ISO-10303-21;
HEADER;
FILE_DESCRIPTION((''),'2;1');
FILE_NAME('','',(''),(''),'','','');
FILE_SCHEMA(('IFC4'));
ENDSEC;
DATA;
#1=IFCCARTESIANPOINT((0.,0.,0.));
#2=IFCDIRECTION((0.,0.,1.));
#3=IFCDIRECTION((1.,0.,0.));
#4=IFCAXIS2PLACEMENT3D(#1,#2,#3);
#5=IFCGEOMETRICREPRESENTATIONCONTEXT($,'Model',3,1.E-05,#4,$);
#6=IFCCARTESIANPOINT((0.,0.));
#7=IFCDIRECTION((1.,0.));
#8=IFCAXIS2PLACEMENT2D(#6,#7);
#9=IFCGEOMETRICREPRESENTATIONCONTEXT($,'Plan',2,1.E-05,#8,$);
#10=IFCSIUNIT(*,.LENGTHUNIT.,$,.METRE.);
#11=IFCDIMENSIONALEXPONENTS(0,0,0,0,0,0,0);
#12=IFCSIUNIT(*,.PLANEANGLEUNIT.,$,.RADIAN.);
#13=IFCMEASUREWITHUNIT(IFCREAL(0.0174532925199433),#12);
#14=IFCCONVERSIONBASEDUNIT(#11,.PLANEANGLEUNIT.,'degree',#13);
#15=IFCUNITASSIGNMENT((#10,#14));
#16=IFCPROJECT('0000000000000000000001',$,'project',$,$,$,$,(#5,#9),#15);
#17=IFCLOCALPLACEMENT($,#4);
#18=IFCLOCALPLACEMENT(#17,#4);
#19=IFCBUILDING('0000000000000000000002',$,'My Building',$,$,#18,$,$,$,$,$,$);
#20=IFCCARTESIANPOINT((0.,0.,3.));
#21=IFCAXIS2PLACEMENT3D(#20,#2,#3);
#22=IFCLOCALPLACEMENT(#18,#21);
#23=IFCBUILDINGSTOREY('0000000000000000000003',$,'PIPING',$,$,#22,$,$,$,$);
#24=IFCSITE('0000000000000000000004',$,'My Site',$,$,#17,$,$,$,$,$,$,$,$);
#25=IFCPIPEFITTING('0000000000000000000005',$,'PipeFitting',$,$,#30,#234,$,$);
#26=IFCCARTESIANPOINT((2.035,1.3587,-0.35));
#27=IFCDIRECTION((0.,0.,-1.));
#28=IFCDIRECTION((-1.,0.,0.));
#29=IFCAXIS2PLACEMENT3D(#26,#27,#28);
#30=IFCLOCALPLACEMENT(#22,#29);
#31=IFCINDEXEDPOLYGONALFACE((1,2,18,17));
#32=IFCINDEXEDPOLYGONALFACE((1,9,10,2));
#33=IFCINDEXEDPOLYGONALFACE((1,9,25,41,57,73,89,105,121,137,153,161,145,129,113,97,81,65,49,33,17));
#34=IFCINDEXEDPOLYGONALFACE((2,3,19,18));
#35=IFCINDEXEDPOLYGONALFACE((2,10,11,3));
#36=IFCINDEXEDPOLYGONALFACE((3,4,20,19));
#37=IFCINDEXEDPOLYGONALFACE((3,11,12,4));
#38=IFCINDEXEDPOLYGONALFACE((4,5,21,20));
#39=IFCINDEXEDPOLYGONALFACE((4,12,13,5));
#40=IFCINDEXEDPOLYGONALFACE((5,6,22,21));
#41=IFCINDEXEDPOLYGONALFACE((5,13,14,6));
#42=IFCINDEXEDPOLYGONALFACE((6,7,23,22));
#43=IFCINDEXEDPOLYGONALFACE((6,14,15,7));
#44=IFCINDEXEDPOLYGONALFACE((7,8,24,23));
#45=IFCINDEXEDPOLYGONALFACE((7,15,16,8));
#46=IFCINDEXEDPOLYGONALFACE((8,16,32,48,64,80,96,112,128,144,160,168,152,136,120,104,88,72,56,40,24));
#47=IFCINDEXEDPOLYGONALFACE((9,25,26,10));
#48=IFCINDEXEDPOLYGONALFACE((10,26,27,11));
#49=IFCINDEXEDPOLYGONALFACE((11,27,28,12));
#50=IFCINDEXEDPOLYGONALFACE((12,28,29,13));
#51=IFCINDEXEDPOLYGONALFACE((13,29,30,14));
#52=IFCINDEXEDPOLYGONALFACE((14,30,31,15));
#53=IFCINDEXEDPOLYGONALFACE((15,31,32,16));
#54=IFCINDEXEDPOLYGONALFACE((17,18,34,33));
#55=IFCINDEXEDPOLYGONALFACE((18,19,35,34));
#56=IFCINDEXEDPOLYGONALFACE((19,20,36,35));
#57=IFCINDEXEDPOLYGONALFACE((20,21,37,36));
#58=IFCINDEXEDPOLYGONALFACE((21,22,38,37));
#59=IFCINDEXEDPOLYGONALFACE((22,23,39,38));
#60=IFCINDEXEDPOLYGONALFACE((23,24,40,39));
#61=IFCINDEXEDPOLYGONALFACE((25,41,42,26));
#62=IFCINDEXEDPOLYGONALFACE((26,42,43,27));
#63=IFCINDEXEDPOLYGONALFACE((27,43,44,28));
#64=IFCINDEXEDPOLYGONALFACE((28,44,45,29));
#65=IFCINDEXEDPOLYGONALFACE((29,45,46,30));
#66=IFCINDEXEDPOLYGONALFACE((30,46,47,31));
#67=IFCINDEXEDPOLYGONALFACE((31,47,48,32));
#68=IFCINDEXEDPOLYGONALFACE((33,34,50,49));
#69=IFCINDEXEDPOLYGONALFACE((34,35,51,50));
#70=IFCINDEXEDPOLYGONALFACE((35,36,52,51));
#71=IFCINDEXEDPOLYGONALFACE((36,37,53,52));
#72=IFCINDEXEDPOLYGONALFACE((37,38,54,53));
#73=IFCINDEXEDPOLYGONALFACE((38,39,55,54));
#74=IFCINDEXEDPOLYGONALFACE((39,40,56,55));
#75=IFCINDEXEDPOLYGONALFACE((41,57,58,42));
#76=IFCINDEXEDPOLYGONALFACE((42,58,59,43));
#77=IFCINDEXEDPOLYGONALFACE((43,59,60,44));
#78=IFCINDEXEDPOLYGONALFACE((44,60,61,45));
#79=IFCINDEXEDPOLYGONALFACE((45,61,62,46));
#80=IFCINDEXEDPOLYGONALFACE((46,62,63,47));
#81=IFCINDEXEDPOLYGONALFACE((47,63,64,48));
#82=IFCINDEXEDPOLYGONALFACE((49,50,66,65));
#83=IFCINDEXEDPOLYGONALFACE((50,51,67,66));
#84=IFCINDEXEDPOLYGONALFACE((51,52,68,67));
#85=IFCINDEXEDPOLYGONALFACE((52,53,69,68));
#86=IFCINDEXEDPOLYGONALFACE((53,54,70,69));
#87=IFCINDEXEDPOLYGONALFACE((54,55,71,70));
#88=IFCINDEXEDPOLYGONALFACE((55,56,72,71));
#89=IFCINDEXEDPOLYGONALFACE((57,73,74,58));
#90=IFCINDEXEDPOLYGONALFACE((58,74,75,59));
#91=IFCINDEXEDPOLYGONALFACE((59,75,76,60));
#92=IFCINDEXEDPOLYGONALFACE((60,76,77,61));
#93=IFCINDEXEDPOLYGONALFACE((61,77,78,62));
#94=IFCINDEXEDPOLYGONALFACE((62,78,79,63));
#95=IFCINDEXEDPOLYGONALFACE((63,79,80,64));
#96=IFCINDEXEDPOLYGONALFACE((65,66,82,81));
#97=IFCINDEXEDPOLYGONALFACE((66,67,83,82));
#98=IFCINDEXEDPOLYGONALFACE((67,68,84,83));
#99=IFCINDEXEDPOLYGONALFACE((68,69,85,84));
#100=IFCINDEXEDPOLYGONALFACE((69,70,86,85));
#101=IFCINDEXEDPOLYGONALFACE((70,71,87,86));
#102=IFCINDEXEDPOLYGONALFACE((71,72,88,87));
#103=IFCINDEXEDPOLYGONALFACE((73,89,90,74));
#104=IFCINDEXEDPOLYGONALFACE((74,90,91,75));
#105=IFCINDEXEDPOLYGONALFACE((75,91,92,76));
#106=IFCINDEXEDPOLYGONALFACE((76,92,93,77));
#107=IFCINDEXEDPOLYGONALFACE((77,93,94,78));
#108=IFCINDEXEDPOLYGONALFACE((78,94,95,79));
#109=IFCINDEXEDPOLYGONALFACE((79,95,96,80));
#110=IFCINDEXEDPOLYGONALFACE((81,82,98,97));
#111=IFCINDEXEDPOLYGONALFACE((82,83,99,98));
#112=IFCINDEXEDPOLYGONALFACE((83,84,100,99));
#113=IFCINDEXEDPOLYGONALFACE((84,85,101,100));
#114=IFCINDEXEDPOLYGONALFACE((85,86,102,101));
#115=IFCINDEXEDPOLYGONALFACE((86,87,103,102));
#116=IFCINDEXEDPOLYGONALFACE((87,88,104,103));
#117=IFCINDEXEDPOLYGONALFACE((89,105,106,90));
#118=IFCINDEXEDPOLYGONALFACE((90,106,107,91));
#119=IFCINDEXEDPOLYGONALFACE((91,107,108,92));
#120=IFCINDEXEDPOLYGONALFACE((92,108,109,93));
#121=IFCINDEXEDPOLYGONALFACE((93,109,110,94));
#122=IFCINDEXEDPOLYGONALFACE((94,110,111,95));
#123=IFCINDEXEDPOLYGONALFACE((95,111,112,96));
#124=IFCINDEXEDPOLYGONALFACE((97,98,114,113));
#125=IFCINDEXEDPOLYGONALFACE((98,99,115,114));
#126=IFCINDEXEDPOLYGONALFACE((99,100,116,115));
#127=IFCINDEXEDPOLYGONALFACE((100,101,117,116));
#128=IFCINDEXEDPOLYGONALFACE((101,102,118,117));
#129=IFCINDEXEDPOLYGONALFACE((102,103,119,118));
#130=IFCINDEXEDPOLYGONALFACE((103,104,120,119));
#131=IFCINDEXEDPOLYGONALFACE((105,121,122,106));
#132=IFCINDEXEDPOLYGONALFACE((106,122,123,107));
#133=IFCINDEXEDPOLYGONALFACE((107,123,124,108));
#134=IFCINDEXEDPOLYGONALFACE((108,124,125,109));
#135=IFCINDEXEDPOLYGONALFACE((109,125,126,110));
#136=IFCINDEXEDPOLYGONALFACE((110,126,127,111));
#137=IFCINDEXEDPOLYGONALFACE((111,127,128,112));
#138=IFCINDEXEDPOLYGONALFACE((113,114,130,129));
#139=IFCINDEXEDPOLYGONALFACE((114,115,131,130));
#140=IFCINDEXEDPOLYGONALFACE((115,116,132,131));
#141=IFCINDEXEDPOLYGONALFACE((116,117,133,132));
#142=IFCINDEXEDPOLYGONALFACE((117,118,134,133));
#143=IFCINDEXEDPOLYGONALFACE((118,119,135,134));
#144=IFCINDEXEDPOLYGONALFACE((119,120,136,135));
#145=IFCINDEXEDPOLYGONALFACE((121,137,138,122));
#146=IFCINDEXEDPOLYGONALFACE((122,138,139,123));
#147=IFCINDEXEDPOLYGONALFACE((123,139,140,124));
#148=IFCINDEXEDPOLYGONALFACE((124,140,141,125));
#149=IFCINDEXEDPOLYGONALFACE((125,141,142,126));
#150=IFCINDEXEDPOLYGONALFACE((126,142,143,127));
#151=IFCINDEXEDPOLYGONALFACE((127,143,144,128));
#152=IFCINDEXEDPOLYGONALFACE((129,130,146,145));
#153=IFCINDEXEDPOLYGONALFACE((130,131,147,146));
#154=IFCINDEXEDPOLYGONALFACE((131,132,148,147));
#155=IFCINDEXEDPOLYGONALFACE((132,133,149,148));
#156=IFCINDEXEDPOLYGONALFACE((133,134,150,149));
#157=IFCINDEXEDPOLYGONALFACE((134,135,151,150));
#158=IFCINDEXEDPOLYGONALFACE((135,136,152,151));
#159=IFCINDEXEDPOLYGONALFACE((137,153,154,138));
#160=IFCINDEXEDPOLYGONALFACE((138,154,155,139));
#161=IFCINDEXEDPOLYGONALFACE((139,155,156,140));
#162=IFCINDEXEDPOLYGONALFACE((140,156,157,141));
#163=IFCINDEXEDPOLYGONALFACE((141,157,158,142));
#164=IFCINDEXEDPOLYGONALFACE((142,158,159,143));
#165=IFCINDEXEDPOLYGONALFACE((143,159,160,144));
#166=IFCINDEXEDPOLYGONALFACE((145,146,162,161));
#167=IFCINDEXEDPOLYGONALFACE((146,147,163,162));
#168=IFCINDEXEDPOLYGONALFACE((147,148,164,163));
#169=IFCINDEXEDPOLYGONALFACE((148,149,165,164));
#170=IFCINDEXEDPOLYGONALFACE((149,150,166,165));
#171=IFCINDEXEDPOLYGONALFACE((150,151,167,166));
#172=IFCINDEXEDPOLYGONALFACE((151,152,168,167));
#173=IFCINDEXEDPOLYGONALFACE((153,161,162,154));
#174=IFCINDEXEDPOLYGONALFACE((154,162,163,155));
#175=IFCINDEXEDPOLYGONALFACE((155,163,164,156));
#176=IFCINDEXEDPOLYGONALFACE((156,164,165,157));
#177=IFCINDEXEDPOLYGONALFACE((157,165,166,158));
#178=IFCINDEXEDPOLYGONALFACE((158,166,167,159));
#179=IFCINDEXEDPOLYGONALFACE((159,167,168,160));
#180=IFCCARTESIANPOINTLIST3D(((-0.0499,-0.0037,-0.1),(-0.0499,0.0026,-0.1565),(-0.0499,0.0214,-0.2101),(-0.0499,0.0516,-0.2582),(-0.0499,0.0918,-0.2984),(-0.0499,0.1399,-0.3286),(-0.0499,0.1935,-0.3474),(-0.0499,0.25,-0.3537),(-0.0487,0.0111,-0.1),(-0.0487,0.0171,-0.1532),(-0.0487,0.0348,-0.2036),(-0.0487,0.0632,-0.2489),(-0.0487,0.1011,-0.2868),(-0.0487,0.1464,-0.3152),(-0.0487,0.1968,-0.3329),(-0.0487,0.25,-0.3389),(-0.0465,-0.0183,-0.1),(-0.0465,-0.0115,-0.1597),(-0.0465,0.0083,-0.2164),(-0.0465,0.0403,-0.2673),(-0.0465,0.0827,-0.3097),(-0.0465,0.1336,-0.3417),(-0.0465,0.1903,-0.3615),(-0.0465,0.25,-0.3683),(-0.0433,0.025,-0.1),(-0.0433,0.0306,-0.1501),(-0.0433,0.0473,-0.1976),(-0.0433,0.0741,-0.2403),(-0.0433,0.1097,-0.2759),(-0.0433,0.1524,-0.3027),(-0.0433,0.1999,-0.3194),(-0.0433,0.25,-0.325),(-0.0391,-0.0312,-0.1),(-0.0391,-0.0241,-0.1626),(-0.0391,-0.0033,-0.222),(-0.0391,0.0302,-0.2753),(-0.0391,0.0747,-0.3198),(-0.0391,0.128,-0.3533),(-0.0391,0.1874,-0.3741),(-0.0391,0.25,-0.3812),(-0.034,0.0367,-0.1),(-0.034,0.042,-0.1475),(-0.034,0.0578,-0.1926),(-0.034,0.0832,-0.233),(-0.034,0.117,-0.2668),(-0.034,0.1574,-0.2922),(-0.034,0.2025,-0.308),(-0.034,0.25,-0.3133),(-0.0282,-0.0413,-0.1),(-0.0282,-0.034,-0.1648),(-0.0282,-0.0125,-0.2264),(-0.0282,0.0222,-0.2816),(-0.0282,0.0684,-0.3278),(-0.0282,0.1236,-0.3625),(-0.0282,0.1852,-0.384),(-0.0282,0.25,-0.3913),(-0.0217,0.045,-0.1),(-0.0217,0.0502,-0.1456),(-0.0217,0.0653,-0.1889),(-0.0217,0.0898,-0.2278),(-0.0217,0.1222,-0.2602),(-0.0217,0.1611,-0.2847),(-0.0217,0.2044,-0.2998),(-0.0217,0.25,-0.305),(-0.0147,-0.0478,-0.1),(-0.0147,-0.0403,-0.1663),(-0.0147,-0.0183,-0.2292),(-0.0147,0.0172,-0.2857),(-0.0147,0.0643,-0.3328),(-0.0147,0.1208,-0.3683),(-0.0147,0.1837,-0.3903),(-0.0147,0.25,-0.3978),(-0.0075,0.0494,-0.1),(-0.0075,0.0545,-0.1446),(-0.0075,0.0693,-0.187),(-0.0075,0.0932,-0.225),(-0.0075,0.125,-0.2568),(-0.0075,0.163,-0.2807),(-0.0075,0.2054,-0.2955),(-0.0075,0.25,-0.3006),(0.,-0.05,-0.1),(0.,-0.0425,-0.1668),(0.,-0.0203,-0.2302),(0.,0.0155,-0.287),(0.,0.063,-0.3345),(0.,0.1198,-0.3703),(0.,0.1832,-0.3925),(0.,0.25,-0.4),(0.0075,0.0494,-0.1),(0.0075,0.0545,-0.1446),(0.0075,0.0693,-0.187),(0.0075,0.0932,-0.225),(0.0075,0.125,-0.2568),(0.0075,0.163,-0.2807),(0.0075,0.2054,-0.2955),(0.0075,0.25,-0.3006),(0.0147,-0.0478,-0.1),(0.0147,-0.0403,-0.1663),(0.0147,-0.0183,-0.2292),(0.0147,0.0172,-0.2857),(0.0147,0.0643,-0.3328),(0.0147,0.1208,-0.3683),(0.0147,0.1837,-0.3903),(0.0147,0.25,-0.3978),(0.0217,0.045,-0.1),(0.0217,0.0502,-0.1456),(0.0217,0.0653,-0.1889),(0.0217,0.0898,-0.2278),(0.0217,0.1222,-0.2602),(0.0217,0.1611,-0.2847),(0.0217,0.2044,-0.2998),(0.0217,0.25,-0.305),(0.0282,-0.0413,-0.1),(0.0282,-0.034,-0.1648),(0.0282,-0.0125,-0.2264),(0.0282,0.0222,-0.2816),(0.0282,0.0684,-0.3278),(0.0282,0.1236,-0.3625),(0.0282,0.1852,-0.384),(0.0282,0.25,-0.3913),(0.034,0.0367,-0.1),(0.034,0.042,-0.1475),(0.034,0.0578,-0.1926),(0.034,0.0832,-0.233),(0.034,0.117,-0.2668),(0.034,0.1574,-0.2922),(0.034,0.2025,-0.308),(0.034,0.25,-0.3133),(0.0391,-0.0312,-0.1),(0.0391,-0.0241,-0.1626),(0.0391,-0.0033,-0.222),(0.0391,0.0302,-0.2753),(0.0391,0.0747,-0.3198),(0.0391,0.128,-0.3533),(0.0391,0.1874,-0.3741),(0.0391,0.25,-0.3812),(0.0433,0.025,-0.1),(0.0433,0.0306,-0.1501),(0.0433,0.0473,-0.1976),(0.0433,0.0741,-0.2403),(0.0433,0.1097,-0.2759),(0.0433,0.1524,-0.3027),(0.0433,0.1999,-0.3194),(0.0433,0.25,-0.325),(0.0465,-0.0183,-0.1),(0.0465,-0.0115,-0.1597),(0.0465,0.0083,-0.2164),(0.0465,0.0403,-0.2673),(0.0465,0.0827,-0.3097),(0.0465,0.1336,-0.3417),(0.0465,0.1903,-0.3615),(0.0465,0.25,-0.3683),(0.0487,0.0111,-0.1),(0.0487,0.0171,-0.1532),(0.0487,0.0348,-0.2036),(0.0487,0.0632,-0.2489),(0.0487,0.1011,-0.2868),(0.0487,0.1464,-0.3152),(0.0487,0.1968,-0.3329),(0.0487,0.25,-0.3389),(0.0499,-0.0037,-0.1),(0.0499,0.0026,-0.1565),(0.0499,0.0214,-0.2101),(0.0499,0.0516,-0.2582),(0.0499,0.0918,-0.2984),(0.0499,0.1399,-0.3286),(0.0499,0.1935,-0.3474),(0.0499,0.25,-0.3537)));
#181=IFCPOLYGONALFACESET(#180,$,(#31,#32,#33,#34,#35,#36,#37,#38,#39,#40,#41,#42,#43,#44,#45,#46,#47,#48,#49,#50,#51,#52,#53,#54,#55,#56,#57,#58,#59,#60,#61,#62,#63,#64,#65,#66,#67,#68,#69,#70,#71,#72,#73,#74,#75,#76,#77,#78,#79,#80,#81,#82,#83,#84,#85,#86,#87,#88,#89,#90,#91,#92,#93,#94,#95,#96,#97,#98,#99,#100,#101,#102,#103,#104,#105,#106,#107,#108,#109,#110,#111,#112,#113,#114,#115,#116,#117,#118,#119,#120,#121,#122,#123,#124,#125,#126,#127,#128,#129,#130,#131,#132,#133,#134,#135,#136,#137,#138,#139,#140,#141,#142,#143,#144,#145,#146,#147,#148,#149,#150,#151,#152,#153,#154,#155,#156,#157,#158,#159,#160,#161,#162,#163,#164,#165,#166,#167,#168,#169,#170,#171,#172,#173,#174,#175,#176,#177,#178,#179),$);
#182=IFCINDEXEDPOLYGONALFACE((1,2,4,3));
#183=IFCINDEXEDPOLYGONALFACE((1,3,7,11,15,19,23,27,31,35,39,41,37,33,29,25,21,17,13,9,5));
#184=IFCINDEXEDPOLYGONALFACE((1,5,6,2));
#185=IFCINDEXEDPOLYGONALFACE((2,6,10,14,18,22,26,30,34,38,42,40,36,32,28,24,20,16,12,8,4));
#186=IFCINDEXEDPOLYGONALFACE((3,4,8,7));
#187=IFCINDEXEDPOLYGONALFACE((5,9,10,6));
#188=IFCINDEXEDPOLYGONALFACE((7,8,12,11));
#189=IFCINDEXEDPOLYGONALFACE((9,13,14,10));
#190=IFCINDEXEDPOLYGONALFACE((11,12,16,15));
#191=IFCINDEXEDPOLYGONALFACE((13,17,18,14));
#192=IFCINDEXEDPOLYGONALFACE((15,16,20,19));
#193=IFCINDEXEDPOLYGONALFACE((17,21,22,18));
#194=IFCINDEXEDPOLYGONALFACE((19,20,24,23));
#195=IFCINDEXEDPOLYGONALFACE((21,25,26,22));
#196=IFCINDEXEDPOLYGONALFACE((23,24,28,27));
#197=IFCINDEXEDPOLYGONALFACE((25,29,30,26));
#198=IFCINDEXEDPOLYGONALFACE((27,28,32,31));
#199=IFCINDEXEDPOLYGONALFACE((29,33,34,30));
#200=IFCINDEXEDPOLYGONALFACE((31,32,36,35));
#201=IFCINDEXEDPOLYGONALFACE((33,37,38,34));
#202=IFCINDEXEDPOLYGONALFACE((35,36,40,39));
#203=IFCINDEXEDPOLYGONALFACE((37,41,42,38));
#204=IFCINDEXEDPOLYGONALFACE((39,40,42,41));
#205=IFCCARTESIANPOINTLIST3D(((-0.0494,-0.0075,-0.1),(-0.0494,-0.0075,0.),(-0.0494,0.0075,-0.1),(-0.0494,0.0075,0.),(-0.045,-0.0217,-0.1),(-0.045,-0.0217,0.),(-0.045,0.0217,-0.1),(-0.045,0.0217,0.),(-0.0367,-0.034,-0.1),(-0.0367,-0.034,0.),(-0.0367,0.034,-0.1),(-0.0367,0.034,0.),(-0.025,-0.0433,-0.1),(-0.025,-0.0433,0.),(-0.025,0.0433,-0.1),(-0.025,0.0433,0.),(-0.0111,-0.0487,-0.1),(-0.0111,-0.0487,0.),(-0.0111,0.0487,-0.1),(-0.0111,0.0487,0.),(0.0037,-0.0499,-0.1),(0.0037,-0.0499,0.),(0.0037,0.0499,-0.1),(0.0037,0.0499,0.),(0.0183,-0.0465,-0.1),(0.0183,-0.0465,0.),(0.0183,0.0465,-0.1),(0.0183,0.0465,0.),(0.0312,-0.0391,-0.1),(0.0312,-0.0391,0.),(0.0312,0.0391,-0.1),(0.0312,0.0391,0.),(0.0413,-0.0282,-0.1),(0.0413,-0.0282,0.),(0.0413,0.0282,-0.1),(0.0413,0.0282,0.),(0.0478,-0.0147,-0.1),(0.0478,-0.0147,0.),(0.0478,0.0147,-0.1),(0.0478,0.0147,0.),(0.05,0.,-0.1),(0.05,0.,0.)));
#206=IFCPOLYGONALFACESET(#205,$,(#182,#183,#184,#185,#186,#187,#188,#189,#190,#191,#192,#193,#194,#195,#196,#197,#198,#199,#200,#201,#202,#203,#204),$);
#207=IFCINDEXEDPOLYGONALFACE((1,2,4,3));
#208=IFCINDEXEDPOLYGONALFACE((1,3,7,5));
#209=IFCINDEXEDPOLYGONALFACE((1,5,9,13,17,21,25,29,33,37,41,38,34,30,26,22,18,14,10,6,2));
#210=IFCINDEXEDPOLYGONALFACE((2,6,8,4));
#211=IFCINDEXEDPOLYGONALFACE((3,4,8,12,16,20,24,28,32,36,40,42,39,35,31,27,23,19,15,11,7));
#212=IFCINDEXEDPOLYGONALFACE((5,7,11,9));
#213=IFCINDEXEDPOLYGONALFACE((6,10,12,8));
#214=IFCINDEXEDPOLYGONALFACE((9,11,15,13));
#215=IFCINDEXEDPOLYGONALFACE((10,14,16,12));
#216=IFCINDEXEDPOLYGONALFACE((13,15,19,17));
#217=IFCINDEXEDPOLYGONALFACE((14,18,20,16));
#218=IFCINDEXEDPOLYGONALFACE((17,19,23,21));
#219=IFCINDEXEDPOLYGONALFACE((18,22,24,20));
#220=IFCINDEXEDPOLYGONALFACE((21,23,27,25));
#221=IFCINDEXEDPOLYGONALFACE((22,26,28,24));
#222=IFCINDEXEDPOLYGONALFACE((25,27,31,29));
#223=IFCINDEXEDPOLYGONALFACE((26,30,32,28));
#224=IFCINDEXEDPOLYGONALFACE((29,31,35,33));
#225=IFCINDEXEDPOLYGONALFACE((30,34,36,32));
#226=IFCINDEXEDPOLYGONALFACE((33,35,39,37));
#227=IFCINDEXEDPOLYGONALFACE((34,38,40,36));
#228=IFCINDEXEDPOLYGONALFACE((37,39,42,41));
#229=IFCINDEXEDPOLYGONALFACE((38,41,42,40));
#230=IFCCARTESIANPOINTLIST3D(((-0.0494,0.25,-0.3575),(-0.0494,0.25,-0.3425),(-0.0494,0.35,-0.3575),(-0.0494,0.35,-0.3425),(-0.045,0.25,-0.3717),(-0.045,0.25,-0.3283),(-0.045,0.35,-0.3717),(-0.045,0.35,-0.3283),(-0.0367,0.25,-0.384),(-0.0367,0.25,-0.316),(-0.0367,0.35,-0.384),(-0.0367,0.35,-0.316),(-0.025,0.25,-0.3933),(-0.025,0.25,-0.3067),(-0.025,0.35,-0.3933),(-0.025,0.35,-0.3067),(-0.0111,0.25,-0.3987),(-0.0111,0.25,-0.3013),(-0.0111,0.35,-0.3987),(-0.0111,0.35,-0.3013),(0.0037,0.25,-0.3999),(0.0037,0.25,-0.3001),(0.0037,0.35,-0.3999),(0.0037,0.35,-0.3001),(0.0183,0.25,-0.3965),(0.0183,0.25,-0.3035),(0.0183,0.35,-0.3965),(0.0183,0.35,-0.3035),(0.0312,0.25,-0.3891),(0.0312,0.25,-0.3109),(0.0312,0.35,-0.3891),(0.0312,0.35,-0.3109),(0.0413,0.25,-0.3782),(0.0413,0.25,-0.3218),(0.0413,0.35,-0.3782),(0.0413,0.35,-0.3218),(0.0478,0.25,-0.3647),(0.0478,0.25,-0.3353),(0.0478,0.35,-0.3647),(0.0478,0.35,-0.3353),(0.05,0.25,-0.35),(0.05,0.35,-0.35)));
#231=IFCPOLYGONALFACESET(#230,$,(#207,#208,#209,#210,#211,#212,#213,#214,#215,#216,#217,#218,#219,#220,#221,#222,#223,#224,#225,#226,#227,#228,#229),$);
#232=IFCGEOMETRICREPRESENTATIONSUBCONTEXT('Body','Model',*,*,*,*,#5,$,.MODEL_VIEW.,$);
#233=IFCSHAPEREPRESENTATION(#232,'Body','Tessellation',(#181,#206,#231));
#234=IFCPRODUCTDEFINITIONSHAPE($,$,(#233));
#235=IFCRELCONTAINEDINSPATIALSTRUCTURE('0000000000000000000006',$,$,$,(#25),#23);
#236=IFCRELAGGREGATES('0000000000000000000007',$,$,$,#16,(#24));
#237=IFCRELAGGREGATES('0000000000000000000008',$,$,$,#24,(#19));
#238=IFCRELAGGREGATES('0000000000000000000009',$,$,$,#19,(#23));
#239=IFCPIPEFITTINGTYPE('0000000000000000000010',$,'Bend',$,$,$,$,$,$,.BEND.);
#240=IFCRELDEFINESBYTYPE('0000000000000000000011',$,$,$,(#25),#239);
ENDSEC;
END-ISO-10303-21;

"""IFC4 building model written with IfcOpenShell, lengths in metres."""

from ifc_helpers import new_model, entity, si_unit, converted_unit, frame, origin_with_axes, origin_2d_with_axis, place, context, subcontext, project, spatial, line, indexed_curve, circle, outline, extrude, source, transform, mapped, type_object, type_shapes, element, save


model = new_model("IFC4")

# Units and contexts
model_context = context("Model", 3, precision=1e-05, world=origin_with_axes())
plan_context = context("Plan", 2, precision=1e-05, world=origin_2d_with_axis())
body_context = subcontext(model_context, "Body", "Model", "MODEL_VIEW")
ifc_project = project(units=[si_unit("LENGTHUNIT", "METRE"), converted_unit("PLANEANGLEUNIT", "degree", entity("IfcReal", 0.0174532925199433), si_unit("PLANEANGLEUNIT", "RADIAN"), dimensions=[0, 0, 0, 0, 0, 0, 0])], contexts=[model_context, plan_context])

# Site, building, storey
site_placement = place(None, origin_with_axes())
site = spatial("IfcSite", under=ifc_project, at=site_placement, Name="My Site")
building_placement = place(site_placement, origin_with_axes())
building = spatial("IfcBuilding", under=site, at=building_placement, Name="My Building")
storey_placement = place(building_placement, frame((0.0, 0.0, 3.0), z_axis=(0.0, 0.0, 1.0), x_axis=(1.0, 0.0, 0.0)))
storey = spatial("IfcBuildingStorey", under=building, at=storey_placement, Name="PIPING")

# Pipe fitting, opening
pipe_fitting_type = type_object("IfcPipeFittingType", Name="Bend", PredefinedType="BEND")
shared_shape = source(origin_with_axes(), body_context, "Body", "SolidModel", [
    entity("IfcSweptDiskSolid", entity("IfcIndexedPolyCurve", entity("IfcCartesianPointList3D", [[0.0, 0.0, -0.1], [0.0, 0.0732, -0.2768], [0.0, 0.25, -0.35]]), [entity("IfcArcIndex", [1, 2, 3])]), 0.05),
    extrude(circle(Radius=0.05), origin_with_axes(), (0.0, 0.0, -1.0), 0.1),
    extrude(circle(Radius=0.05), frame((0.0, 0.25, -0.35), z_axis=(0.0, 1.0, 0.0), x_axis=(1.0, 0.0, 0.0)), (0.0, 0.0, 1.0), 0.1),
])
type_shapes(pipe_fitting_type, [shared_shape])
pipe_fitting_1_placement = place(storey_placement, frame((2.035, 1.3587, -0.35), z_axis=(0.0, 0.0, -1.0), x_axis=(-1.0, 0.0, 0.0)))
pipe_fitting_1 = element("IfcPipeFitting", 1, at=pipe_fitting_1_placement, inside=storey, type_object=pipe_fitting_type, Name="PipeFitting", context=body_context, shape_type="MappedRepresentation", body=[
    mapped(shared_shape, transform((0.0, 0.0, 0.0), x_axis=(1.0, 0.0, 0.0), y_axis=(0.0, 1.0, 0.0), z_axis=(0.0, 0.0, 1.0), scale=1.0)),
])
opening_1_placement = place(pipe_fitting_1_placement, frame((1.768, -1.3587, 2.65), z_axis=(0.0, 0.0, -1.0), x_axis=(-1.0, 0.0, 0.0)))
element("IfcOpeningElement", 2, at=opening_1_placement, cuts=pipe_fitting_1, PredefinedType="OPENING", context=body_context, shape_type="SweptSolid", body=[
    extrude(outline(indexed_curve([(0.0, 0.0), (0.5, 0.0), (0.5, 0.5), (0.0, 0.5)], segments=[line(1, 2, 3, 4, 1)])), origin_with_axes(), (0.0, 0.0, 1.0), 0.5),
])

save(model, "model.ifc")
